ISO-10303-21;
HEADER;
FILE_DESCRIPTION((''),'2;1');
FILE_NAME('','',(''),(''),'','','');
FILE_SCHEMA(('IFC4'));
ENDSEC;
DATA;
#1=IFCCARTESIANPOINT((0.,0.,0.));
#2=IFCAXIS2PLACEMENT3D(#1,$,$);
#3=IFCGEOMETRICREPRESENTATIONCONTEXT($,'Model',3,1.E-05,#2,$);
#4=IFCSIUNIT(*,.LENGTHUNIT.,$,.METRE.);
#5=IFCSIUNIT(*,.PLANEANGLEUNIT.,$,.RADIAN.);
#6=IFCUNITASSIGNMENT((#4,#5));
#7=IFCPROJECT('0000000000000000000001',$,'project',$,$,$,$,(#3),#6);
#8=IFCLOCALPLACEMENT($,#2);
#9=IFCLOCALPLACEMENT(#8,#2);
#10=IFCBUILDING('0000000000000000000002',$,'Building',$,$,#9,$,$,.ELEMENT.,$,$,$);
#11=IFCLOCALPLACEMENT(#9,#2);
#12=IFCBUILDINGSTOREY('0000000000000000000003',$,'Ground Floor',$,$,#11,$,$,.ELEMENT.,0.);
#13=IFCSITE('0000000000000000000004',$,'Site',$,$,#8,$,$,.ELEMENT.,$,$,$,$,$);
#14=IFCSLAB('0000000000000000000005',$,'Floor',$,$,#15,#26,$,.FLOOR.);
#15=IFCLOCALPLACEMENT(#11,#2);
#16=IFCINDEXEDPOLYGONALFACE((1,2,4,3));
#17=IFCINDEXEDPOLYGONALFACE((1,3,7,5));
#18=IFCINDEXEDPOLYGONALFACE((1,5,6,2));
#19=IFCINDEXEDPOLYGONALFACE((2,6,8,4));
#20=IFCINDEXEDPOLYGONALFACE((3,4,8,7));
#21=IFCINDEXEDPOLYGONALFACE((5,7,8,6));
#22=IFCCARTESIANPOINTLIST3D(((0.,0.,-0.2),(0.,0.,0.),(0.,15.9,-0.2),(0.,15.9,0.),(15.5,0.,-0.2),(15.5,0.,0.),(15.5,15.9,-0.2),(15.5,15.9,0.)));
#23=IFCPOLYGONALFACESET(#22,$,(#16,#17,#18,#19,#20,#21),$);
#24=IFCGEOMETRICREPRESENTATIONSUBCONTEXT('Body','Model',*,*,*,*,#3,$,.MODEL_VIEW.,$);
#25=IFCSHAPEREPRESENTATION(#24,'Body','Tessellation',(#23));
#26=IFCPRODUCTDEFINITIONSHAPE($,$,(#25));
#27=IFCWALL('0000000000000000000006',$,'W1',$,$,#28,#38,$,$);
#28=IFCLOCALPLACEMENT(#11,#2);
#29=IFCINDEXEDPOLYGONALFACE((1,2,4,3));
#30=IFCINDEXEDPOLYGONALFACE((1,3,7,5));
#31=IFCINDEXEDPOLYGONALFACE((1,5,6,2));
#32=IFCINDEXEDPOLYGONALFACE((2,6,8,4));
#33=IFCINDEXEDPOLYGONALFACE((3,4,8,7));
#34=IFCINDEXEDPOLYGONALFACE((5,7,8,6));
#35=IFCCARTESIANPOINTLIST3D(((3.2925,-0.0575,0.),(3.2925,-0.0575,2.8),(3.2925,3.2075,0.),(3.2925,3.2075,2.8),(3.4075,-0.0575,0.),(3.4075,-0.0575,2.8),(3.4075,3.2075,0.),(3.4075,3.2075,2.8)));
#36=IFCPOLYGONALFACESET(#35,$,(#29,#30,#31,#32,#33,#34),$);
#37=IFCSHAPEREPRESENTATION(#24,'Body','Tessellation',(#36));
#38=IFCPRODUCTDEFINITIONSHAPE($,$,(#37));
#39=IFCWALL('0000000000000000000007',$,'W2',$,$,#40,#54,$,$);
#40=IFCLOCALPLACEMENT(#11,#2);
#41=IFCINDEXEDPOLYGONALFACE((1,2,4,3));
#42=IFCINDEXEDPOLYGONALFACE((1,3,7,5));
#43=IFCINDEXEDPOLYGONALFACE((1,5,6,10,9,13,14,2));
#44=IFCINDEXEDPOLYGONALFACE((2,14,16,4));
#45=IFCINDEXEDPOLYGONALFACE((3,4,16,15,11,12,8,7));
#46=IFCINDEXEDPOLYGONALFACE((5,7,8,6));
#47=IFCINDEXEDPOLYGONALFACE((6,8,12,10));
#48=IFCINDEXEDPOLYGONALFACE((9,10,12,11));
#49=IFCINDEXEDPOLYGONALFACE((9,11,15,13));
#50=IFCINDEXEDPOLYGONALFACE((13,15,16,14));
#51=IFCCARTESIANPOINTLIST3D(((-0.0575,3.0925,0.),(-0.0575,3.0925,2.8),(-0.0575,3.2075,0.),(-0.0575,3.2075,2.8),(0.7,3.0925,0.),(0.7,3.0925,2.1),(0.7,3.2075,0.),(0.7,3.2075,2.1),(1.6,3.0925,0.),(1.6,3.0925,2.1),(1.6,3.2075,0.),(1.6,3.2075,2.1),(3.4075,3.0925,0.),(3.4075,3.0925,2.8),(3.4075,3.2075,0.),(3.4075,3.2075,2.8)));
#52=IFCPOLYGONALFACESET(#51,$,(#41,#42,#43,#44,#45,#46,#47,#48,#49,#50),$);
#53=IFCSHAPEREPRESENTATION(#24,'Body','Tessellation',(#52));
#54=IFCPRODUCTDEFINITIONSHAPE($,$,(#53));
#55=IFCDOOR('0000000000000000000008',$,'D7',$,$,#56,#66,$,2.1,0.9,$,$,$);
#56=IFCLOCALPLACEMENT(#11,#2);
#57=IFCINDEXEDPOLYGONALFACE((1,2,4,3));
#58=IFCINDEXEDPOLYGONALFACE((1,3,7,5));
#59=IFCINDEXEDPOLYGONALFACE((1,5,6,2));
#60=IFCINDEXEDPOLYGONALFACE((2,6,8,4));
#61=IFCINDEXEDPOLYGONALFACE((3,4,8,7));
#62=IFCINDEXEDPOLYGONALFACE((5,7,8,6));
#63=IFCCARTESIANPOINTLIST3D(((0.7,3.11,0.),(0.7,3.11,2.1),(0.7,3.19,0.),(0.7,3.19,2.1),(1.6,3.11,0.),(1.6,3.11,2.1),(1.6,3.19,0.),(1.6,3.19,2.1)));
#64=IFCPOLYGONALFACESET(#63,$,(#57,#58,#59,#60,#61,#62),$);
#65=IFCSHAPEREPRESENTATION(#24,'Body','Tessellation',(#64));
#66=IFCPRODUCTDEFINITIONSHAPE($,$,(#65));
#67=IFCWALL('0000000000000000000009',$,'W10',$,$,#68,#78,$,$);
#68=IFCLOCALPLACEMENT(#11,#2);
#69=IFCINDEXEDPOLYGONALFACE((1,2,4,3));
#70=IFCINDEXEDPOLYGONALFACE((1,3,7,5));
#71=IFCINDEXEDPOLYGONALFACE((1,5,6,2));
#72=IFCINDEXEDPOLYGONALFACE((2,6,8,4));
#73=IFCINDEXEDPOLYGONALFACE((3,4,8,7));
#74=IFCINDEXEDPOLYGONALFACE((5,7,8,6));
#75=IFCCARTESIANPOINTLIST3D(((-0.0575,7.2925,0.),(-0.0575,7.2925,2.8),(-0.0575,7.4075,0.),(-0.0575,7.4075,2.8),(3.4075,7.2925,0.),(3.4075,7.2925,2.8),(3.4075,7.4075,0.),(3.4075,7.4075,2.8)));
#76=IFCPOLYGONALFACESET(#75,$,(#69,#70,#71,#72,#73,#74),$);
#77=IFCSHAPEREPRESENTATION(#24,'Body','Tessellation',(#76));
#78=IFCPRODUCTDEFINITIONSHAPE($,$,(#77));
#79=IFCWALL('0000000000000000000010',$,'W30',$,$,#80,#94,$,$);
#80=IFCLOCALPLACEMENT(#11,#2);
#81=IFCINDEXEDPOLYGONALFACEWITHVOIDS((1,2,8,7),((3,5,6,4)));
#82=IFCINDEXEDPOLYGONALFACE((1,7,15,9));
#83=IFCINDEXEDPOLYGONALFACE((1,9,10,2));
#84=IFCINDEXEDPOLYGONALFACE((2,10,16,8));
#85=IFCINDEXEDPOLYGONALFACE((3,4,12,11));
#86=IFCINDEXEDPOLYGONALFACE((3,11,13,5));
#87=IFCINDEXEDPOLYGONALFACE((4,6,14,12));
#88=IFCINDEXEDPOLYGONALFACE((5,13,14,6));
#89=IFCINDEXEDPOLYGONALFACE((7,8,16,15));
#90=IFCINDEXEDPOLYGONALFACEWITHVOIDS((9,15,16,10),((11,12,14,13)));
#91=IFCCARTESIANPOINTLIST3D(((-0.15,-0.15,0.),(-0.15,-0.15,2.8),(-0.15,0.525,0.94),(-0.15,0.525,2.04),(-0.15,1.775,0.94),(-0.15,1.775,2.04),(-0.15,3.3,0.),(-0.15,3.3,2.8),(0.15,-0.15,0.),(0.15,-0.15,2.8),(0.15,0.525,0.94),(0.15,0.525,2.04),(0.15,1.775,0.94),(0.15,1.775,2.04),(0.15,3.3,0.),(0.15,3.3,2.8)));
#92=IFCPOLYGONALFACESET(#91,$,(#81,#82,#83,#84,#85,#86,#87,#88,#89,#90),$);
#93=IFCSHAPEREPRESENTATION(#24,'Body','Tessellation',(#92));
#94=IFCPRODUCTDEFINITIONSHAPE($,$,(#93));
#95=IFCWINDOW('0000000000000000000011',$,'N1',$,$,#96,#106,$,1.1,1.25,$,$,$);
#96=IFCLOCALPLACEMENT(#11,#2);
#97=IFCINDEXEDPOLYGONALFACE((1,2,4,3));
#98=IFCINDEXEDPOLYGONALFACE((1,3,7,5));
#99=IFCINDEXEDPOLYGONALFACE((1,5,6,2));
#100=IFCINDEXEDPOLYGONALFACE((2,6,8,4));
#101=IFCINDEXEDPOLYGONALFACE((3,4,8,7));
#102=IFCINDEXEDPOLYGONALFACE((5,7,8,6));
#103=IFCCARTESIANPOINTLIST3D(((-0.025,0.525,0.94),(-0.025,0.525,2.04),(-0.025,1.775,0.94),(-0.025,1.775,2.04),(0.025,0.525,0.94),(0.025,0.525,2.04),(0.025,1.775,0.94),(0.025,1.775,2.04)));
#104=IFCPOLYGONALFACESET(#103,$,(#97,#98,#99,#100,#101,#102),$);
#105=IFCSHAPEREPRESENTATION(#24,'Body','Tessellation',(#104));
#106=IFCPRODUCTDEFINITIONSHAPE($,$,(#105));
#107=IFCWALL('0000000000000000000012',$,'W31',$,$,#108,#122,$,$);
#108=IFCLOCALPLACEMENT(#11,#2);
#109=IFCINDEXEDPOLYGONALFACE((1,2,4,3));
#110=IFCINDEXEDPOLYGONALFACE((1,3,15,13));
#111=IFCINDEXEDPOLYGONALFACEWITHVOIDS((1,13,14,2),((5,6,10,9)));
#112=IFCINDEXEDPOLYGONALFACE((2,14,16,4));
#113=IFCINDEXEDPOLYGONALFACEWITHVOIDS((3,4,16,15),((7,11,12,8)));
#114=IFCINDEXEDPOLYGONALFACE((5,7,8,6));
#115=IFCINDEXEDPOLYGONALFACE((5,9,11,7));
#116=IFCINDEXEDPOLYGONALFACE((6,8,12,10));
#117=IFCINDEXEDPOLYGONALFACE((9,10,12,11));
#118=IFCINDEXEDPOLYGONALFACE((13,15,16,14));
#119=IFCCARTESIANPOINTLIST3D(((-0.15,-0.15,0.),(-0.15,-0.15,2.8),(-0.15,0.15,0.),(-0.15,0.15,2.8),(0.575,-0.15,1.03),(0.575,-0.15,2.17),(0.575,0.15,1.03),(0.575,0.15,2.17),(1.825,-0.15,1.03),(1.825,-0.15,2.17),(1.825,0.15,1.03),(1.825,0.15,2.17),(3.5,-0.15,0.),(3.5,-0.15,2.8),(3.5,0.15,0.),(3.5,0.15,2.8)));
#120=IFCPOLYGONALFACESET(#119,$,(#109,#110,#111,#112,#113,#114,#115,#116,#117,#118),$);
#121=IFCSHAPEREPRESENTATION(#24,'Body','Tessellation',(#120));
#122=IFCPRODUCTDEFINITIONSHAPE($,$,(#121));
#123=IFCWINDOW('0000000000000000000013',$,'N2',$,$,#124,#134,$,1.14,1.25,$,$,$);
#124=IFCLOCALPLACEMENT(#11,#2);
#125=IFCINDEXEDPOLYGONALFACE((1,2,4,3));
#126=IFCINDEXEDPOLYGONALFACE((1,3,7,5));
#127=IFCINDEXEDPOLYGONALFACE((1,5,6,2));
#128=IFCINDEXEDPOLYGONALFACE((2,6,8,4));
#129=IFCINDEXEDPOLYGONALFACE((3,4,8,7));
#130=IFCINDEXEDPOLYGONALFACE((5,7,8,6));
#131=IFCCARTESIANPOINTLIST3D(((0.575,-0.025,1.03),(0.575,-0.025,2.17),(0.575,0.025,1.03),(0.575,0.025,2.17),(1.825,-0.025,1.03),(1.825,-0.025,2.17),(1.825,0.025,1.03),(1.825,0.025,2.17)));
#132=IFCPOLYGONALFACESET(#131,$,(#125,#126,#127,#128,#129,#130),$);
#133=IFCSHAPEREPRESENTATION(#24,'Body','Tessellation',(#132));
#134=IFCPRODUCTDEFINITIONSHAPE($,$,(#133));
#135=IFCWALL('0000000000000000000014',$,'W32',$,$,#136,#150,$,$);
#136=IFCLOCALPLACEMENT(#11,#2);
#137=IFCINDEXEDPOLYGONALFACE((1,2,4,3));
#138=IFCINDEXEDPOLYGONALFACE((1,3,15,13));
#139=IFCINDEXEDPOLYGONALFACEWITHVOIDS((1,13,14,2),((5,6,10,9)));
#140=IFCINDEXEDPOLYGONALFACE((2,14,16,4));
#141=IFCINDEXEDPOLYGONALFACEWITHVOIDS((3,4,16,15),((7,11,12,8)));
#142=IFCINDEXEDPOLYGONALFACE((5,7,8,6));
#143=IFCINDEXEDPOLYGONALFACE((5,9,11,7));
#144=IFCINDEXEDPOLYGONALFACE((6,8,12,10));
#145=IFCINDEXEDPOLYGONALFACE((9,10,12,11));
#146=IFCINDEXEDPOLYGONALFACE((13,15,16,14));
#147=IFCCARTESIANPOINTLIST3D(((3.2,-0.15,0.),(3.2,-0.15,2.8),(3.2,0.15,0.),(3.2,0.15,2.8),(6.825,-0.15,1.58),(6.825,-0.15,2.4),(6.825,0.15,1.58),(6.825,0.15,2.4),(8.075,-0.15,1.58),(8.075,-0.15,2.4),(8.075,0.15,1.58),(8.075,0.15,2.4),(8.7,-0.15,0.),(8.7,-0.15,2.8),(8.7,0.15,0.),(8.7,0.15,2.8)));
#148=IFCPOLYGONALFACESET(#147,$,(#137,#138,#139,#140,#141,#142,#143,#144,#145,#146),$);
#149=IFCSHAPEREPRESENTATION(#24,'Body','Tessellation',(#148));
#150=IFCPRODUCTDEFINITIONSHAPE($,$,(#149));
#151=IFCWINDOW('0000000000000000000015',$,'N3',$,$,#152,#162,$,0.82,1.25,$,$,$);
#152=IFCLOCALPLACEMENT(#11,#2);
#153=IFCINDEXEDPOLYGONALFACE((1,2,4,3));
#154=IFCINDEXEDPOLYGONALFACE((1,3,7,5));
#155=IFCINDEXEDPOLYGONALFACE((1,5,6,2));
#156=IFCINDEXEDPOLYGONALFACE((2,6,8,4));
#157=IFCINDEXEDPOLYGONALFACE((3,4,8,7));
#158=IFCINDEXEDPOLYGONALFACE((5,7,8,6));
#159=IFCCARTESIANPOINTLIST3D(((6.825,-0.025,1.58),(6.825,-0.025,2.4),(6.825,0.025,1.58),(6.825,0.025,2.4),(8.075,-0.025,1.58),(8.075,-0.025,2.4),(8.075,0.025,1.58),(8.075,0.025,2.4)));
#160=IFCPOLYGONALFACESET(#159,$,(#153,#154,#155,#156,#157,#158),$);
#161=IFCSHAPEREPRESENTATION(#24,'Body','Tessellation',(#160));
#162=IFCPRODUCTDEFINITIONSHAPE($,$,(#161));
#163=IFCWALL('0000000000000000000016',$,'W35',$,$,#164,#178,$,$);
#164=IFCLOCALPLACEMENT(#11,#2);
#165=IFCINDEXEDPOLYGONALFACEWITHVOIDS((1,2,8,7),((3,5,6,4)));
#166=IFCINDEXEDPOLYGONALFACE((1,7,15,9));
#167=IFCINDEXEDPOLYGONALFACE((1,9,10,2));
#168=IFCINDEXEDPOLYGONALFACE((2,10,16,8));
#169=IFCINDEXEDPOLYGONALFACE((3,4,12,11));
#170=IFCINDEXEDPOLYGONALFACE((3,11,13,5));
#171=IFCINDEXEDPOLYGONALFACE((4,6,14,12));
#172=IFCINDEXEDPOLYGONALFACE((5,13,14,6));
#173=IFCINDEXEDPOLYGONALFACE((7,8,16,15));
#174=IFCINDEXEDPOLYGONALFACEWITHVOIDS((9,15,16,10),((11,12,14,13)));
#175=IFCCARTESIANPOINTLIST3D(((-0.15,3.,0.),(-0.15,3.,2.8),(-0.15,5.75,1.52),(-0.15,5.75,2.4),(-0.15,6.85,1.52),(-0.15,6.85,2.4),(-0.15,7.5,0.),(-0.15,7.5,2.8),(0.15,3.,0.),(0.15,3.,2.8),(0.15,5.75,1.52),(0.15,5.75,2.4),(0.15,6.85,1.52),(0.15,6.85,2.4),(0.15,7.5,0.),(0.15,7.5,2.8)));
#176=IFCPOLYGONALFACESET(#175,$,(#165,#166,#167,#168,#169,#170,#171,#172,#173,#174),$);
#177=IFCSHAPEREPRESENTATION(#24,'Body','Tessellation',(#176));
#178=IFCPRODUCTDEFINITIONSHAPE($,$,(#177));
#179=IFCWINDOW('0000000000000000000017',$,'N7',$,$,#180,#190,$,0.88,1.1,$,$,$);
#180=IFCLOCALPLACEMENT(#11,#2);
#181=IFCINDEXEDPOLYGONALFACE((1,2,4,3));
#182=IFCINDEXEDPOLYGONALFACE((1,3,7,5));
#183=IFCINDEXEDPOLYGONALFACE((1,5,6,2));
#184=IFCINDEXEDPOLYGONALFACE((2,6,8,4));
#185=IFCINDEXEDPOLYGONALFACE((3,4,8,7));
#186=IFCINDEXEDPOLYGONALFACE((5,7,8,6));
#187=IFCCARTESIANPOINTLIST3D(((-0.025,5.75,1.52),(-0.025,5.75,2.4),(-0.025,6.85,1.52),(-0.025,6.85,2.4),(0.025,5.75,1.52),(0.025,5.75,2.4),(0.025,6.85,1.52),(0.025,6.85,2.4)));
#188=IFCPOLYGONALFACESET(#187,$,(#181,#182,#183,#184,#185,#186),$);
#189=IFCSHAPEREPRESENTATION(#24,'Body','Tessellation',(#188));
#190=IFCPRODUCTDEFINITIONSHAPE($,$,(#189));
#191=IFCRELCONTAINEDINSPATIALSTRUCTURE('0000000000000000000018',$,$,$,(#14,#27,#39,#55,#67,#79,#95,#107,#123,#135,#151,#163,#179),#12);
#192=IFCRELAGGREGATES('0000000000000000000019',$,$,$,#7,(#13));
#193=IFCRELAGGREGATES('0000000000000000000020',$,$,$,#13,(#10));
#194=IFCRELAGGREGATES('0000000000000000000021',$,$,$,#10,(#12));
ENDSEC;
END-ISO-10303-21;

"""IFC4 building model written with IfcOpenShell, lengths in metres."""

from ifc_helpers import new_model, si_unit, frame, frame_2d, origin, origin_2d, place, context, subcontext, project, spatial, polyline, rectangle, outline, extrude, element, fill, save


model = new_model("IFC4")

# Units and contexts
model_context = context("Model", 3, precision=1e-05, world=origin())
body_context = subcontext(model_context, "Body", "Model", "MODEL_VIEW")
ifc_project = project(units=[si_unit("LENGTHUNIT", "METRE"), si_unit("PLANEANGLEUNIT", "RADIAN")], contexts=[model_context])

# Site, building, storey
site_placement = place(None, origin())
site = spatial("IfcSite", under=ifc_project, at=site_placement, Name="Site", CompositionType="ELEMENT")
building_placement = place(site_placement, origin())
building = spatial("IfcBuilding", under=site, at=building_placement, Name="Building", CompositionType="ELEMENT")
storey_placement = place(building_placement, origin())
storey = spatial("IfcBuildingStorey", under=building, at=storey_placement, Name="Ground Floor", CompositionType="ELEMENT", Elevation=0.0)

# Slab
slab_placement = place(storey_placement, origin())
element("IfcSlab", 1, at=slab_placement, inside=storey, Name="Floor", PredefinedType="FLOOR", context=body_context, shape_type="SweptSolid", body=[
    extrude(outline(polyline([(0.0, 0.0), (15.5, 0.0), (15.5, 15.9), (0.0, 15.9), (0.0, 0.0)])), origin(), (0.0, 0.0, -1.0), 0.2),
])

# Wall
wall_1_placement = place(storey_placement, frame((3.35, 0.0, 0.0), x_axis=(0.0, 1.0, 0.0)))
element("IfcWall", 2, at=wall_1_placement, inside=storey, Name="W1", context=body_context, shape_type="SweptSolid", body=[
    extrude(rectangle(XDim=3.265, YDim=0.115, at=frame_2d((1.575, 0.0))), origin(), (0.0, 0.0, 1.0), 2.8),
])

# Wall, opening, door
wall_2_placement = place(storey_placement, frame((0.0, 3.15, 0.0), x_axis=(1.0, 0.0, 0.0)))
wall_2 = element("IfcWall", 3, at=wall_2_placement, inside=storey, Name="W2", context=body_context, shape_type="SweptSolid", body=[
    extrude(rectangle(XDim=3.465, YDim=0.115, at=frame_2d((1.675, 0.0))), origin(), (0.0, 0.0, 1.0), 2.8),
])
opening_1_placement = place(wall_2_placement, frame((1.15, 0.0, 0.0)))
opening_1 = element("IfcOpeningElement", 4, at=opening_1_placement, cuts=wall_2, context=body_context, shape_type="SweptSolid", body=[
    extrude(rectangle(XDim=0.9, YDim=0.215, at=origin_2d()), origin(), (0.0, 0.0, 1.0), 2.1),
])
door_1_placement = place(opening_1_placement, origin())
door_1 = element("IfcDoor", 5, at=door_1_placement, inside=storey, Name="D7", OverallHeight=2.1, OverallWidth=0.9, context=body_context, shape_type="SweptSolid", body=[
    extrude(rectangle(XDim=0.9, YDim=0.08, at=origin_2d()), origin(), (0.0, 0.0, 1.0), 2.1),
])
fill(opening_1, door_1)

# Wall
wall_3_placement = place(storey_placement, frame((0.0, 7.35, 0.0), x_axis=(1.0, 0.0, 0.0)))
element("IfcWall", 6, at=wall_3_placement, inside=storey, Name="W10", context=body_context, shape_type="SweptSolid", body=[
    extrude(rectangle(XDim=3.465, YDim=0.115, at=frame_2d((1.675, 0.0))), origin(), (0.0, 0.0, 1.0), 2.8),
])

# Walls, openings, windows
wall_4_placement = place(storey_placement, frame((0.0, 0.0, 0.0), x_axis=(0.0, 1.0, 0.0)))
wall_4 = element("IfcWall", 7, at=wall_4_placement, inside=storey, Name="W30", context=body_context, shape_type="SweptSolid", body=[
    extrude(rectangle(XDim=3.45, YDim=0.3, at=frame_2d((1.575, 0.0))), origin(), (0.0, 0.0, 1.0), 2.8),
])
opening_2_placement = place(wall_4_placement, frame((1.15, 0.0, 0.94)))
opening_2 = element("IfcOpeningElement", 8, at=opening_2_placement, cuts=wall_4, context=body_context, shape_type="SweptSolid", body=[
    extrude(rectangle(XDim=1.25, YDim=0.4, at=origin_2d()), origin(), (0.0, 0.0, 1.0), 1.1),
])
window_1_placement = place(opening_2_placement, origin())
window_1 = element("IfcWindow", 9, at=window_1_placement, inside=storey, Name="N1", OverallHeight=1.1, OverallWidth=1.25, context=body_context, shape_type="SweptSolid", body=[
    extrude(rectangle(XDim=1.25, YDim=0.05, at=origin_2d()), origin(), (0.0, 0.0, 1.0), 1.1),
])
fill(opening_2, window_1)
wall_5_placement = place(storey_placement, frame((0.0, 0.0, 0.0), x_axis=(1.0, 0.0, 0.0)))
wall_5 = element("IfcWall", 10, at=wall_5_placement, inside=storey, Name="W31", context=body_context, shape_type="SweptSolid", body=[
    extrude(rectangle(XDim=3.65, YDim=0.3, at=frame_2d((1.675, 0.0))), origin(), (0.0, 0.0, 1.0), 2.8),
])
opening_3_placement = place(wall_5_placement, frame((1.2, 0.0, 1.03)))
opening_3 = element("IfcOpeningElement", 11, at=opening_3_placement, cuts=wall_5, context=body_context, shape_type="SweptSolid", body=[
    extrude(rectangle(XDim=1.25, YDim=0.4, at=origin_2d()), origin(), (0.0, 0.0, 1.0), 1.14),
])
window_2_placement = place(opening_3_placement, origin())
window_2 = element("IfcWindow", 12, at=window_2_placement, inside=storey, Name="N2", OverallHeight=1.14, OverallWidth=1.25, context=body_context, shape_type="SweptSolid", body=[
    extrude(rectangle(XDim=1.25, YDim=0.05, at=origin_2d()), origin(), (0.0, 0.0, 1.0), 1.14),
])
fill(opening_3, window_2)
wall_6_placement = place(storey_placement, frame((3.35, 0.0, 0.0), x_axis=(1.0, 0.0, 0.0)))
wall_6 = element("IfcWall", 13, at=wall_6_placement, inside=storey, Name="W32", context=body_context, shape_type="SweptSolid", body=[
    extrude(rectangle(XDim=5.5, YDim=0.3, at=frame_2d((2.6, 0.0))), origin(), (0.0, 0.0, 1.0), 2.8),
])
opening_4_placement = place(wall_6_placement, frame((4.1, 0.0, 1.58)))
opening_4 = element("IfcOpeningElement", 14, at=opening_4_placement, cuts=wall_6, context=body_context, shape_type="SweptSolid", body=[
    extrude(rectangle(XDim=1.25, YDim=0.4, at=origin_2d()), origin(), (0.0, 0.0, 1.0), 0.82),
])
window_3_placement = place(opening_4_placement, origin())
window_3 = element("IfcWindow", 15, at=window_3_placement, inside=storey, Name="N3", OverallHeight=0.82, OverallWidth=1.25, context=body_context, shape_type="SweptSolid", body=[
    extrude(rectangle(XDim=1.25, YDim=0.05, at=origin_2d()), origin(), (0.0, 0.0, 1.0), 0.82),
])
fill(opening_4, window_3)
wall_7_placement = place(storey_placement, frame((0.0, 3.15, 0.0), x_axis=(0.0, 1.0, 0.0)))
wall_7 = element("IfcWall", 16, at=wall_7_placement, inside=storey, Name="W35", context=body_context, shape_type="SweptSolid", body=[
    extrude(rectangle(XDim=4.5, YDim=0.3, at=frame_2d((2.1, 0.0))), origin(), (0.0, 0.0, 1.0), 2.8),
])
opening_5_placement = place(wall_7_placement, frame((3.15, 0.0, 1.52)))
opening_5 = element("IfcOpeningElement", 17, at=opening_5_placement, cuts=wall_7, context=body_context, shape_type="SweptSolid", body=[
    extrude(rectangle(XDim=1.1, YDim=0.4, at=origin_2d()), origin(), (0.0, 0.0, 1.0), 0.88),
])
window_4_placement = place(opening_5_placement, origin())
window_4 = element("IfcWindow", 18, at=window_4_placement, inside=storey, Name="N7", OverallHeight=0.88, OverallWidth=1.1, context=body_context, shape_type="SweptSolid", body=[
    extrude(rectangle(XDim=1.1, YDim=0.05, at=origin_2d()), origin(), (0.0, 0.0, 1.0), 0.88),
])
fill(opening_5, window_4)

save(model, "model.ifc")
